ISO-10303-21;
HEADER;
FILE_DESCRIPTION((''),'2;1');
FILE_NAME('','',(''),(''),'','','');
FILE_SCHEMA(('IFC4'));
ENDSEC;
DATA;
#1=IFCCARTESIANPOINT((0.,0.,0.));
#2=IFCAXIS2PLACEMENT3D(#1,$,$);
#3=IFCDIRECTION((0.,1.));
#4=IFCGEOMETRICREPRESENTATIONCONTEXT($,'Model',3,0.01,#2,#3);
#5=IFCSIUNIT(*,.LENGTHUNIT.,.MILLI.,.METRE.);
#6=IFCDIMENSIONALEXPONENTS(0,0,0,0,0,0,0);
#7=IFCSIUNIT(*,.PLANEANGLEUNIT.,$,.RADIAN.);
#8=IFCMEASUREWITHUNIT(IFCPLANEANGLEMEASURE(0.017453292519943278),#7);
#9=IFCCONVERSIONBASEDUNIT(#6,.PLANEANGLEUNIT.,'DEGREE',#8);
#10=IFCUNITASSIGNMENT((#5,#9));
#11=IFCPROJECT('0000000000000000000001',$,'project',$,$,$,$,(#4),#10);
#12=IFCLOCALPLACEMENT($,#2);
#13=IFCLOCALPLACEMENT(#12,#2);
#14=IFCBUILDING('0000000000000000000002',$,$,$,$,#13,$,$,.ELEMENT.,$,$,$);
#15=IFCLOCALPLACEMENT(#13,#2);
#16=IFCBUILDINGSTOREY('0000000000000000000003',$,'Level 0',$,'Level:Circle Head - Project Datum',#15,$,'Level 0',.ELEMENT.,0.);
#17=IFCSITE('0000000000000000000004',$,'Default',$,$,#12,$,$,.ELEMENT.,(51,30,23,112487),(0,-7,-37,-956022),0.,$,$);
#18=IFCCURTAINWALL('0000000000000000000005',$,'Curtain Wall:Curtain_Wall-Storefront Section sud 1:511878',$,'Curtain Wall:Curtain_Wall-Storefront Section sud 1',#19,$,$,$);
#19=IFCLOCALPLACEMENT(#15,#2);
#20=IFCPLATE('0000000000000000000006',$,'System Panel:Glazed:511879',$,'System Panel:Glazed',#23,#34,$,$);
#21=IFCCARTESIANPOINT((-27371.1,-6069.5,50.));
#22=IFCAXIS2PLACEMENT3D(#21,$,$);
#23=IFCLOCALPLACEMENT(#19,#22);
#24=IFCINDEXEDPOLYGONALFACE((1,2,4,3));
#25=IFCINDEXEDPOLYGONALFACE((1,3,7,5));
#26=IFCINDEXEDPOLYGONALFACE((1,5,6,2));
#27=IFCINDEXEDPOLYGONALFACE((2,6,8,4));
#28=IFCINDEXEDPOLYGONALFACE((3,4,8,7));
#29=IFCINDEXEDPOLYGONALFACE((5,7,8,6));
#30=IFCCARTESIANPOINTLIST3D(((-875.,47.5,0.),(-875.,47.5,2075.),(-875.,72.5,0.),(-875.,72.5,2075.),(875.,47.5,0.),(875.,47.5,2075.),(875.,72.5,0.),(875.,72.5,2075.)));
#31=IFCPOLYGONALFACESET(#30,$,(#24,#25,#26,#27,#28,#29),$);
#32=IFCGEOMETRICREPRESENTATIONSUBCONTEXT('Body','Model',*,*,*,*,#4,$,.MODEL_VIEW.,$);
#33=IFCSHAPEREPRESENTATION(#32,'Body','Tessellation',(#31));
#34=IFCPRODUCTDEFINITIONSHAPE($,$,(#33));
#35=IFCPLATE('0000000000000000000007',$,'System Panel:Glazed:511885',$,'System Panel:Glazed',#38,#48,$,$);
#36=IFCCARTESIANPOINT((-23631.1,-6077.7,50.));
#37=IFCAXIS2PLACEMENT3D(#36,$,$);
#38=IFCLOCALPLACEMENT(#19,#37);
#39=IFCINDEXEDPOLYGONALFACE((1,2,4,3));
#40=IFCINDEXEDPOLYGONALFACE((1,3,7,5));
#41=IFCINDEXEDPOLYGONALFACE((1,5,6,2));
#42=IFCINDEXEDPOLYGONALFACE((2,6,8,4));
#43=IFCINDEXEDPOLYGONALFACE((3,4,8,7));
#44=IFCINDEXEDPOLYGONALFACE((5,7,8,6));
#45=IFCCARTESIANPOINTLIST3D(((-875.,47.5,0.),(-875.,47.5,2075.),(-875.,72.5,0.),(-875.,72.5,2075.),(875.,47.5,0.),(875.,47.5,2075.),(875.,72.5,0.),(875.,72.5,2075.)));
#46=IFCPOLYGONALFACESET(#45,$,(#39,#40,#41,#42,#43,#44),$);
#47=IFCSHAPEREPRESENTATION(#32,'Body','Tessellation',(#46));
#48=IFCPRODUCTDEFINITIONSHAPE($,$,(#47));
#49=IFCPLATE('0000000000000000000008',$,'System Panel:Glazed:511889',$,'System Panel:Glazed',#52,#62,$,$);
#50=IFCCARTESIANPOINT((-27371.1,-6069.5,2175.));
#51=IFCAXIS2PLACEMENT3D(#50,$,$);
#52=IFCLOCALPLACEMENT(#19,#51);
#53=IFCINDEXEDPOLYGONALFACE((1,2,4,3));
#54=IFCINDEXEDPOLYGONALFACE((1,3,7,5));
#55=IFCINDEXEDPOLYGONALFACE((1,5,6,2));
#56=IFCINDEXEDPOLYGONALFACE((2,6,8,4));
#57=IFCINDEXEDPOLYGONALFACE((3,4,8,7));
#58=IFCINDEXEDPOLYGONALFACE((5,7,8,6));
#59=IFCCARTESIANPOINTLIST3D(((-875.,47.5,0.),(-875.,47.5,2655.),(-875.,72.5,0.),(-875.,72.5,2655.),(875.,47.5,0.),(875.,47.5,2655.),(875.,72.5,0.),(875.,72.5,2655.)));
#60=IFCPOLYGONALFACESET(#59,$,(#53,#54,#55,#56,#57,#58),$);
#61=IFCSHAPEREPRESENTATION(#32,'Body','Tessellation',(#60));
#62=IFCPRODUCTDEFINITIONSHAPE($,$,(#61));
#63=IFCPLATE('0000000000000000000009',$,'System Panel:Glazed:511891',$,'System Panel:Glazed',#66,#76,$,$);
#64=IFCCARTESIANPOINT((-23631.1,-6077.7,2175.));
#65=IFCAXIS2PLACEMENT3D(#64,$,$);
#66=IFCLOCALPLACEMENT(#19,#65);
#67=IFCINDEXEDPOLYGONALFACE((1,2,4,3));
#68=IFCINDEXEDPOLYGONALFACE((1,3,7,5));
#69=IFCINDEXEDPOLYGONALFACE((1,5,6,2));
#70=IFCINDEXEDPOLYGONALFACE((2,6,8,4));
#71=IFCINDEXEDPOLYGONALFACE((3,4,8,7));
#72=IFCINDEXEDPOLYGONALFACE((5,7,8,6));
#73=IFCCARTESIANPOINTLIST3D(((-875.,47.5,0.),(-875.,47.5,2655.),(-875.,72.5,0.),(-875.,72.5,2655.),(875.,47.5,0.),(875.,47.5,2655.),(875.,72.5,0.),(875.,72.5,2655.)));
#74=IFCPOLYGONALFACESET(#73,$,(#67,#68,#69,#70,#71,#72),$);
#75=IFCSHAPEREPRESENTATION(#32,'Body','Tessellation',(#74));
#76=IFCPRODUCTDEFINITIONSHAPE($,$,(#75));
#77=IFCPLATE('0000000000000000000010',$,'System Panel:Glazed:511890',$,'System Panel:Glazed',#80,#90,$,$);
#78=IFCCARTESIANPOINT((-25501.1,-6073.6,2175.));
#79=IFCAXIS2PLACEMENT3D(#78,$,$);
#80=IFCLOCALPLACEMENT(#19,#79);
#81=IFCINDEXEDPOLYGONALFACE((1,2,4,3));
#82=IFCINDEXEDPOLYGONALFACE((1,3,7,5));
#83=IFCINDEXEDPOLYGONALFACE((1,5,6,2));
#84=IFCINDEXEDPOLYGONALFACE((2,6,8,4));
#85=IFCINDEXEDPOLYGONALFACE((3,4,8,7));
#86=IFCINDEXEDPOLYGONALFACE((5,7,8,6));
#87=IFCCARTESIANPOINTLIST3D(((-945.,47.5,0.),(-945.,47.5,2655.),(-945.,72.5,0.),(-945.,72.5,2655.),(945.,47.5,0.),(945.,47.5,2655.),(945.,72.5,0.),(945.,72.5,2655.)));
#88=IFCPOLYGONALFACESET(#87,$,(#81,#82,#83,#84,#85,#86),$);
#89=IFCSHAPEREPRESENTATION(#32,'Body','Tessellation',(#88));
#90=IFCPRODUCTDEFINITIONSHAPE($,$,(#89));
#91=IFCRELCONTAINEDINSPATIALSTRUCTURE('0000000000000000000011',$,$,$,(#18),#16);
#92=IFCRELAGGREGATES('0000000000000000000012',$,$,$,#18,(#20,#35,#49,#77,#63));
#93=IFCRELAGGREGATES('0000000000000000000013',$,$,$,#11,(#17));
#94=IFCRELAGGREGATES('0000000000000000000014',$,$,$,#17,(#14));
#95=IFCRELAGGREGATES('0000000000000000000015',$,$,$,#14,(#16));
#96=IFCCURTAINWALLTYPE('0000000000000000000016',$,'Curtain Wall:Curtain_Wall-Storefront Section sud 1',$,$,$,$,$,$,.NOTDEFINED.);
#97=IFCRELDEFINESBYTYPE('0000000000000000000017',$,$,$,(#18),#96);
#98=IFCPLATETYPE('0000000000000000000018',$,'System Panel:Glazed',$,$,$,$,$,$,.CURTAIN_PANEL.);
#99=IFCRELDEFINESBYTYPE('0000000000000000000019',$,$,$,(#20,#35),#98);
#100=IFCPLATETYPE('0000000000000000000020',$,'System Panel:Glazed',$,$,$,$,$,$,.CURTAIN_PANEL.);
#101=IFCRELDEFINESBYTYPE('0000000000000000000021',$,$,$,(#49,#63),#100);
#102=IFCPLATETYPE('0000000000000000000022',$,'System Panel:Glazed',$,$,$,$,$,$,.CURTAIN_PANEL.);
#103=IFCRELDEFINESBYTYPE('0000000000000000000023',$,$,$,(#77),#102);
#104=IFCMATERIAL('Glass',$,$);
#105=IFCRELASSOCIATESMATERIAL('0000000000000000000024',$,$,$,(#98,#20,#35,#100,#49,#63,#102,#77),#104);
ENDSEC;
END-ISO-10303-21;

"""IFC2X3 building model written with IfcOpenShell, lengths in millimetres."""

from ifc_helpers import new_model, entity, si_unit, converted_unit, direction, frame, frame_2d, origin, origin_2d_with_axis, place, context, subcontext, project, spatial, rectangle, extrude, source, transform, mapped, material, type_object, type_shapes, element, aggregate, save


model = new_model("IFC2X3")

# Units and contexts
model_context = context("Model", 3, precision=0.01, world=origin(), true_north=direction((0.0, 1.0)))
body_context = subcontext(model_context, "Body", "Model", "MODEL_VIEW")
ifc_project = project(units=[si_unit("LENGTHUNIT", "METRE", prefix="MILLI"), converted_unit("PLANEANGLEUNIT", "DEGREE", entity("IfcPlaneAngleMeasure", 0.017453292519943278), si_unit("PLANEANGLEUNIT", "RADIAN"), dimensions=[0, 0, 0, 0, 0, 0, 0])], contexts=[model_context])

# Site, building, storey
site_placement = place(None, origin())
site = spatial("IfcSite", under=ifc_project, at=site_placement, Name="Default", CompositionType="ELEMENT", RefLatitude=(51, 30, 23, 112487), RefLongitude=(0, -7, -37, -956022), RefElevation=0.0)
building_placement = place(site_placement, origin())
building = spatial("IfcBuilding", under=site, at=building_placement, CompositionType="ELEMENT")
storey_placement = place(building_placement, origin())
storey = spatial("IfcBuildingStorey", under=building, at=storey_placement, Name="Level 0", ObjectType="Level:Circle Head - Project Datum", LongName="Level 0", CompositionType="ELEMENT", Elevation=0.0)

# Shared definitions
curtain_wall_type = type_object("IfcCurtainWallType", Name="Curtain Wall:Curtain_Wall-Storefront Section sud 1", PredefinedType="NOTDEFINED")

# Curtain wall
curtain_wall_1_placement = place(storey_placement, origin())
curtain_wall_1 = element("IfcCurtainWall", 1, at=curtain_wall_1_placement, inside=storey, type_object=curtain_wall_type, Name="Curtain Wall:Curtain_Wall-Storefront Section sud 1:511878", ObjectType="Curtain Wall:Curtain_Wall-Storefront Section sud 1")

# Plates
ifc_material_1 = material(Name="Glass")
plate_type_1 = type_object("IfcPlateType", Name="System Panel:Glazed", PredefinedType="CURTAIN_PANEL", material=ifc_material_1)
shared_shape_1 = source(origin(), body_context, "Body", "SweptSolid", [
    extrude(rectangle(XDim=25.0, YDim=1750.0, at=origin_2d_with_axis()), frame((0.0, 60.0, 0.0), z_axis=(0.0, 0.0, 1.0), x_axis=(0.0, 1.0, 0.0)), (0.0, 0.0, 1.0), 2075.0),
])
type_shapes(plate_type_1, [shared_shape_1])
plate_1_placement = place(curtain_wall_1_placement, frame((-27371.1, -6069.5, 50.0)))
plate_1 = element("IfcPlate", 2, at=plate_1_placement, type_object=plate_type_1, material=ifc_material_1, Name="System Panel:Glazed:511879", ObjectType="System Panel:Glazed", context=body_context, shape_type="MappedRepresentation", body=[
    mapped(shared_shape_1, transform((0.0, 0.0, 0.0), scale=1.0)),
])
plate_2_placement = place(curtain_wall_1_placement, frame((-23631.1, -6077.7, 50.0)))
plate_2 = element("IfcPlate", 3, at=plate_2_placement, type_object=plate_type_1, material=ifc_material_1, Name="System Panel:Glazed:511885", ObjectType="System Panel:Glazed", context=body_context, shape_type="MappedRepresentation", body=[
    mapped(shared_shape_1, transform((0.0, 0.0, 0.0), scale=1.0)),
])
plate_type_2 = type_object("IfcPlateType", Name="System Panel:Glazed", PredefinedType="CURTAIN_PANEL", material=ifc_material_1)
shared_shape_2 = source(origin(), body_context, "Body", "SweptSolid", [
    extrude(rectangle(XDim=25.0, YDim=1750.0, at=frame_2d((0.0, 0.0), x_axis=(1.0, 0.0))), frame((0.0, 60.0, 0.0), z_axis=(0.0, 0.0, 1.0), x_axis=(0.0, 1.0, 0.0)), (0.0, 0.0, 1.0), 2655.0),
])
type_shapes(plate_type_2, [shared_shape_2])
plate_3_placement = place(curtain_wall_1_placement, frame((-27371.1, -6069.5, 2175.0)))
plate_3 = element("IfcPlate", 4, at=plate_3_placement, type_object=plate_type_2, material=ifc_material_1, Name="System Panel:Glazed:511889", ObjectType="System Panel:Glazed", context=body_context, shape_type="MappedRepresentation", body=[
    mapped(shared_shape_2, transform((0.0, 0.0, 0.0), scale=1.0)),
])
plate_4_placement = place(curtain_wall_1_placement, frame((-23631.1, -6077.7, 2175.0)))
plate_4 = element("IfcPlate", 5, at=plate_4_placement, type_object=plate_type_2, material=ifc_material_1, Name="System Panel:Glazed:511891", ObjectType="System Panel:Glazed", context=body_context, shape_type="MappedRepresentation", body=[
    mapped(shared_shape_2, transform((0.0, 0.0, 0.0), scale=1.0)),
])
plate_type_3 = type_object("IfcPlateType", Name="System Panel:Glazed", PredefinedType="CURTAIN_PANEL", material=ifc_material_1)
shared_shape_3 = source(origin(), body_context, "Body", "SweptSolid", [
    extrude(rectangle(XDim=25.0, YDim=1890.0, at=frame_2d((0.0, 0.0), x_axis=(1.0, 0.0))), frame((0.0, 60.0, 0.0), z_axis=(0.0, 0.0, 1.0), x_axis=(0.0, 1.0, 0.0)), (0.0, 0.0, 1.0), 2655.0),
])
type_shapes(plate_type_3, [shared_shape_3])
plate_5_placement = place(curtain_wall_1_placement, frame((-25501.1, -6073.6, 2175.0)))
plate_5 = element("IfcPlate", 6, at=plate_5_placement, type_object=plate_type_3, material=ifc_material_1, Name="System Panel:Glazed:511890", ObjectType="System Panel:Glazed", context=body_context, shape_type="MappedRepresentation", body=[
    mapped(shared_shape_3, transform((0.0, 0.0, 0.0), scale=1.0)),
])
aggregate(curtain_wall_1, [plate_1, plate_2, plate_3, plate_5, plate_4])

save(model, "model.ifc")
